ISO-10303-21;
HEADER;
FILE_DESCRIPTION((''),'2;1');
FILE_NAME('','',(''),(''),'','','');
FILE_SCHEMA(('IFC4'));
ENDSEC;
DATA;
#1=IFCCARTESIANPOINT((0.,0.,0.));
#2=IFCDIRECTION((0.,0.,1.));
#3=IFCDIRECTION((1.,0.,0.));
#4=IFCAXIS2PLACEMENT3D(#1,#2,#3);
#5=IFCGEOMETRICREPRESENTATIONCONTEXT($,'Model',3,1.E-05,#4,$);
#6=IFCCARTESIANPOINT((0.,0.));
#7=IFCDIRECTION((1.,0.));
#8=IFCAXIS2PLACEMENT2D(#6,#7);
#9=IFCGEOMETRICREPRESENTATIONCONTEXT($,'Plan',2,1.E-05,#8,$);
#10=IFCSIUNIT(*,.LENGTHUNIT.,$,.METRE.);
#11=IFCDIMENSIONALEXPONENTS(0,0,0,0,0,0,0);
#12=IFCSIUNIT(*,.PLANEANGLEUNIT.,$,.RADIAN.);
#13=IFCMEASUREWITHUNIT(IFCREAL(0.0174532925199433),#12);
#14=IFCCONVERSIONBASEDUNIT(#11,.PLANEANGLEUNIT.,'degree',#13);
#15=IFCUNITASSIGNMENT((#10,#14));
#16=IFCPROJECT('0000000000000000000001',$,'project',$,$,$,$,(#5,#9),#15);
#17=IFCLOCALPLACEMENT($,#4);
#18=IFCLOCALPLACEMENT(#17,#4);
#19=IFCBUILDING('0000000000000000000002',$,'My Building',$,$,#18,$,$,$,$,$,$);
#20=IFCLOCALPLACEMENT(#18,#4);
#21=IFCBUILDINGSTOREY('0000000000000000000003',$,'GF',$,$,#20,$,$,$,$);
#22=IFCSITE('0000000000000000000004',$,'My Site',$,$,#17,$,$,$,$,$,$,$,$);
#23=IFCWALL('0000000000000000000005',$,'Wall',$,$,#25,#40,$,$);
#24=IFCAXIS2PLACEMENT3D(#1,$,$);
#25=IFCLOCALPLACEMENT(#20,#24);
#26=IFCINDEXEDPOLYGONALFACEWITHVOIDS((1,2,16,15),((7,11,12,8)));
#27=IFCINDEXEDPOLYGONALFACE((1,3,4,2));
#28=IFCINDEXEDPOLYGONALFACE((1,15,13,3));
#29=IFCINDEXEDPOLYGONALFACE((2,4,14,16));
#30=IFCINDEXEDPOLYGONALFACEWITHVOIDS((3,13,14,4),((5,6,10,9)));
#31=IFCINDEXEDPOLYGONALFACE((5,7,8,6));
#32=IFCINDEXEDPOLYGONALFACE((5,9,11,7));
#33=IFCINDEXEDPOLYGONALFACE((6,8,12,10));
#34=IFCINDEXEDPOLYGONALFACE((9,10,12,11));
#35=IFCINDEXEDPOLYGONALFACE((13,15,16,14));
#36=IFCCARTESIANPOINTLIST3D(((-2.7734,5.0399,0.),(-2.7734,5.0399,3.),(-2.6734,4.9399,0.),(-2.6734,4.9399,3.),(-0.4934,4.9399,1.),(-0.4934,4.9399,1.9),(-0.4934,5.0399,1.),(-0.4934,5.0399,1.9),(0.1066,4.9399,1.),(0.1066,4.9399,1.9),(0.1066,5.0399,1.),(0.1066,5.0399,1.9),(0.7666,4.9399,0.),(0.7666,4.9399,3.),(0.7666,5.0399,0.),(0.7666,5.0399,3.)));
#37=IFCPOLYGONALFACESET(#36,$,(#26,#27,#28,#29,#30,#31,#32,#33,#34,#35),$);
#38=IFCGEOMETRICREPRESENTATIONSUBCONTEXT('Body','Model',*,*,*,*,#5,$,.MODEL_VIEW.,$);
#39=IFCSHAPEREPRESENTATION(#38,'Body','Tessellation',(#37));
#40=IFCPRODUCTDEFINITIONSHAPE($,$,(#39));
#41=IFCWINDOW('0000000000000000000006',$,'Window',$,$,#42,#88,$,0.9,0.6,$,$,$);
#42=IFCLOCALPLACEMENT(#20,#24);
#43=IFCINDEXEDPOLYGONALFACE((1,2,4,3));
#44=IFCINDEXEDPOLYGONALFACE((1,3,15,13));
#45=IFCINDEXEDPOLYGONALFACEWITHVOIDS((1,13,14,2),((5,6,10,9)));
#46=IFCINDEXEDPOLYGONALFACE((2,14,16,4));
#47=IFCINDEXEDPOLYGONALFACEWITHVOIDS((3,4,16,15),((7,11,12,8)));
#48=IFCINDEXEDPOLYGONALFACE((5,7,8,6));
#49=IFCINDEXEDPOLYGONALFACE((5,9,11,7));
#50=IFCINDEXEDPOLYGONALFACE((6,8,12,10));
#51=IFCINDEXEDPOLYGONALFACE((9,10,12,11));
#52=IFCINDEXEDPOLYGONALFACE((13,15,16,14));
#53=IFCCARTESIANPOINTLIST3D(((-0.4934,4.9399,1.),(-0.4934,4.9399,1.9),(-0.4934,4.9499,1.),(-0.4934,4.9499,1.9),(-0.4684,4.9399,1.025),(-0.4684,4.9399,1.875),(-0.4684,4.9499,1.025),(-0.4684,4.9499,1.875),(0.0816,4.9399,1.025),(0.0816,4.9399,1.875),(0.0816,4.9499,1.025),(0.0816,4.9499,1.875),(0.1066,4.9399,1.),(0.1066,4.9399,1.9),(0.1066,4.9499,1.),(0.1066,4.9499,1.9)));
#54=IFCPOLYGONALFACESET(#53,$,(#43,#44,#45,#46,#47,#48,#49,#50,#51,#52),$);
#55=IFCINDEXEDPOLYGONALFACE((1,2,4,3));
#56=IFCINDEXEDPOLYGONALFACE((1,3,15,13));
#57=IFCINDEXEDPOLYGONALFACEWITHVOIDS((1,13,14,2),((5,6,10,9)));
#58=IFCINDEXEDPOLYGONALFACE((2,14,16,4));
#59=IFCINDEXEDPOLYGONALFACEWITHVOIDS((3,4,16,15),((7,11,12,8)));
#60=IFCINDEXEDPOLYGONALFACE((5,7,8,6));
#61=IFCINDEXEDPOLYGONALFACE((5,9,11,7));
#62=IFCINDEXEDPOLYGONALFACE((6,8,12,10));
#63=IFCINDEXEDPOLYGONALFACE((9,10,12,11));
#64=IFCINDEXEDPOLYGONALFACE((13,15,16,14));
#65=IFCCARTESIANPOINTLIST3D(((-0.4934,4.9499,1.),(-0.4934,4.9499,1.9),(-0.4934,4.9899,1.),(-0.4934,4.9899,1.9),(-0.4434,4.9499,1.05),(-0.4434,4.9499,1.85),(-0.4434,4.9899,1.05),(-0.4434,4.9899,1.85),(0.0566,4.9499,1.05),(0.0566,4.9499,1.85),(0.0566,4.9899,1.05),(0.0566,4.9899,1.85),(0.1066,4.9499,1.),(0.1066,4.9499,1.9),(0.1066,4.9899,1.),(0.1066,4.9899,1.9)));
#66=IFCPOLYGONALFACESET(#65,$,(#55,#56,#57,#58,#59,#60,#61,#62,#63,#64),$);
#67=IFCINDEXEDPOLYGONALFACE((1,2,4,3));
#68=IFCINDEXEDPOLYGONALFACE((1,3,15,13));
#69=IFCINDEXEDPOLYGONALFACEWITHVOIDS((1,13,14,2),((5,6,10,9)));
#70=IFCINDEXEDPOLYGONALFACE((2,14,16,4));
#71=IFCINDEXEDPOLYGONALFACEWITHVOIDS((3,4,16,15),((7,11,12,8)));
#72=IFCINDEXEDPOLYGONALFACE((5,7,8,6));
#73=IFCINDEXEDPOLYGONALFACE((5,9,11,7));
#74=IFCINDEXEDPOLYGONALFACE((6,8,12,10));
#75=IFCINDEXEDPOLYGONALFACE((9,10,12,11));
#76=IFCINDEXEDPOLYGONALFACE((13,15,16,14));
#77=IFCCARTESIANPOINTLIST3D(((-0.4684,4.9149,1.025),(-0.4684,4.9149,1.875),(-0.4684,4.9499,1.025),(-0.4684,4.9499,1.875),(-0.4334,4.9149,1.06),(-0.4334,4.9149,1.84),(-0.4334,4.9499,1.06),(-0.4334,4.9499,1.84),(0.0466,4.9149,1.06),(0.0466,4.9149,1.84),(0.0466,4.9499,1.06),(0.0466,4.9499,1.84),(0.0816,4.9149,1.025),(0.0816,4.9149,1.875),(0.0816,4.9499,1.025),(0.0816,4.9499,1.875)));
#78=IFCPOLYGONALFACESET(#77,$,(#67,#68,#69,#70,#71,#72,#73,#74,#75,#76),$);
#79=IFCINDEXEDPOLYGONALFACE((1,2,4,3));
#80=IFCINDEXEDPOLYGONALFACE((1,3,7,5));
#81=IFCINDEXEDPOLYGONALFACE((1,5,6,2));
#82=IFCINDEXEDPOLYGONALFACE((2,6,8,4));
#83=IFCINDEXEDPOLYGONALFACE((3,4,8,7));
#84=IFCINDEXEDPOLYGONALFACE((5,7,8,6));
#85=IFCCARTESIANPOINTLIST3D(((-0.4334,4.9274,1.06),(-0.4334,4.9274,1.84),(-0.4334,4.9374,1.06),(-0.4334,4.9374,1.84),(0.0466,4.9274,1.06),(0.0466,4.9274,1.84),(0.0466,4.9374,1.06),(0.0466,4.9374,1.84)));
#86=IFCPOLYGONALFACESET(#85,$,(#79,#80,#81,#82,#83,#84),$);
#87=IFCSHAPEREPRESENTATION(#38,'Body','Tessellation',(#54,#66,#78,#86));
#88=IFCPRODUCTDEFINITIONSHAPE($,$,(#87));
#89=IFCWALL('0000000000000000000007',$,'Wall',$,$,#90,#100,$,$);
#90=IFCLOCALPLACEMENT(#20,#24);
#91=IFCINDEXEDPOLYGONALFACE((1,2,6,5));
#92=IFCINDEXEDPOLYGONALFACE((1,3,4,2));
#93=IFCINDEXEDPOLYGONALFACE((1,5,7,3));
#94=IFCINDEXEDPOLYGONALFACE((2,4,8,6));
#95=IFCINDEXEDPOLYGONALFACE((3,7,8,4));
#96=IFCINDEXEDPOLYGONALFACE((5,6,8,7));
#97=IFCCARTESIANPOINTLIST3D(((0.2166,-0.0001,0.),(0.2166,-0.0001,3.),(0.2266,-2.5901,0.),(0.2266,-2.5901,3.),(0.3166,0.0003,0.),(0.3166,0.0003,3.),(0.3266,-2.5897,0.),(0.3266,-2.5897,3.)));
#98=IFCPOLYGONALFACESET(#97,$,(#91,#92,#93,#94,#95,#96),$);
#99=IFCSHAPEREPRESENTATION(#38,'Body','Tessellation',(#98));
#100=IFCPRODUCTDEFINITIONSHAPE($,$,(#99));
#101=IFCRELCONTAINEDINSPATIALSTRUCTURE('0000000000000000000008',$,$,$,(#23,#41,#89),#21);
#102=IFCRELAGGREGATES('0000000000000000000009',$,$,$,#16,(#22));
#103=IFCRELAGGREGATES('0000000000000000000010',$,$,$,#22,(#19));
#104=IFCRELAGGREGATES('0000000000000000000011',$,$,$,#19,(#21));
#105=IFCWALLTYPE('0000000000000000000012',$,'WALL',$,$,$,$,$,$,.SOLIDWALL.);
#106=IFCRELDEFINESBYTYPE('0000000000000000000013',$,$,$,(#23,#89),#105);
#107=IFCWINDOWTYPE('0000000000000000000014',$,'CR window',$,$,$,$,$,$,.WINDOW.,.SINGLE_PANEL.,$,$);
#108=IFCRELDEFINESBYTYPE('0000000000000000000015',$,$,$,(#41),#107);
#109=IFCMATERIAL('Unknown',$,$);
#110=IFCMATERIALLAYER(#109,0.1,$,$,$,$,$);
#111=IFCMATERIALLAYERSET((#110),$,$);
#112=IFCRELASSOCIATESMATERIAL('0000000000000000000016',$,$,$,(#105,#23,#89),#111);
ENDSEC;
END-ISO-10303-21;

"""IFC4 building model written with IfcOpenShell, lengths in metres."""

from ifc_helpers import new_model, entity, si_unit, converted_unit, frame, origin_with_axes, origin_2d_with_axis, place, context, subcontext, project, spatial, line, indexed_curve, outline, extrude, shape, source, transform, mapped, material, layer, layer_set, layer_usage, type_object, type_shapes, element, fill, save


model = new_model("IFC4")

# Units and contexts
model_context = context("Model", 3, precision=1e-05, world=origin_with_axes())
plan_context = context("Plan", 2, precision=1e-05, world=origin_2d_with_axis())
body_context_1 = subcontext(model_context, "Body", "Model", "MODEL_VIEW")
body_context_2 = subcontext(plan_context, "Body", "Plan", "PLAN_VIEW")
ifc_project = project(units=[si_unit("LENGTHUNIT", "METRE"), converted_unit("PLANEANGLEUNIT", "degree", entity("IfcReal", 0.0174532925199433), si_unit("PLANEANGLEUNIT", "RADIAN"), dimensions=[0, 0, 0, 0, 0, 0, 0])], contexts=[model_context, plan_context])

# Site, building, storey
site_placement = place(None, origin_with_axes())
site = spatial("IfcSite", under=ifc_project, at=site_placement, Name="My Site")
building_placement = place(site_placement, origin_with_axes())
building = spatial("IfcBuilding", under=site, at=building_placement, Name="My Building")
storey_placement = place(building_placement, origin_with_axes())
storey = spatial("IfcBuildingStorey", under=building, at=storey_placement, Name="GF")

# Shared definitions
ifc_material = material(Name="Unknown")

# Shared definitions
ifc_layer_1 = layer(ifc_material, 0.1)
ifc_layer_set_1 = layer_set([ifc_layer_1])
wall_type_1 = type_object("IfcWallType", Name="WALL", PredefinedType="SOLIDWALL", material=ifc_layer_set_1)

# Wall, opening, window
ifc_layer_usage_1 = layer_usage(ifc_layer_set_1, "AXIS2", "POSITIVE", 0.0)
wall_1_placement = place(storey_placement, frame((0.7666, 5.0399, 0.0), z_axis=(0.0, 0.0, 1.0), x_axis=(-1.0, 0.0, 0.0)))
wall_1 = element("IfcWall", 1, at=wall_1_placement, inside=storey, type_object=wall_type_1, material=ifc_layer_usage_1, Name="Wall", context=body_context_1, shape_type="SweptSolid", body=[
    extrude(outline(indexed_curve([(0.0, 0.0), (0.0, 0.1), (3.44, 0.1), (3.54, 0.0)], segments=[line(1, 2, 3, 4, 1)])), origin_with_axes(), (0.0, 0.0, 1.0), 3.0),
])
shared_shape_1 = source(origin_with_axes(), body_context_1, "Body", "SweptSolid", [
    extrude(outline(indexed_curve([(0.0, 0.0), (0.6, 0.0), (0.6, 0.9), (0.0, 0.9)], segments=[line(1, 2, 3, 4, 1)])), frame((0.0, -0.6, 0.0), z_axis=(0.0, -1.0, 0.0), x_axis=(1.0, 0.0, 0.0)), (0.0, 0.0, -1.0), 1.2),
])
opening_1_placement = place(wall_1_placement, frame((0.66, 0.0, 1.0), z_axis=(0.0, 0.0, 1.0), x_axis=(1.0, 0.0, 0.0)))
opening_1 = element("IfcOpeningElement", 2, at=opening_1_placement, cuts=wall_1, PredefinedType="OPENING", context=body_context_1, shape_type="MappedRepresentation", body=[
    mapped(shared_shape_1, transform((0.0, 0.0, 0.0), x_axis=(1.0, 0.0, 0.0), y_axis=(0.0, 1.0, 0.0), z_axis=(0.0, 0.0, 1.0), scale=1.0)),
])
window_type_1 = type_object("IfcWindowType", Name="CR window", PartitioningType="SINGLE_PANEL", PredefinedType="WINDOW")
shared_shape_2 = source(origin_with_axes(), body_context_1, "Body", "SweptSolid", [
    extrude(outline(indexed_curve([(0.0, 0.0), (0.6, 0.0), (0.6, 0.9), (0.0, 0.9)], segments=[line(1, 2, 3, 4, 1)]), holes=[indexed_curve([(0.025, 0.025), (0.575, 0.025), (0.575, 0.875), (0.025, 0.875)], segments=[line(1, 2, 3, 4, 1)])]), frame((0.0, 0.09, 0.0), z_axis=(0.0, -1.0, 0.0), x_axis=(1.0, 0.0, 0.0)), (0.0, 0.0, -1.0), 0.01),
    extrude(outline(indexed_curve([(0.0, 0.0), (0.6, 0.0), (0.6, 0.9), (0.0, 0.9)], segments=[line(1, 2, 3, 4, 1)]), holes=[indexed_curve([(0.05, 0.05), (0.55, 0.05), (0.55, 0.85), (0.05, 0.85)], segments=[line(1, 2, 3, 4, 1)])]), frame((0.0, 0.05, 0.0), z_axis=(0.0, -1.0, 0.0), x_axis=(1.0, 0.0, 0.0)), (0.0, 0.0, -1.0), 0.04),
    extrude(outline(indexed_curve([(0.0, 0.0), (0.55, 0.0), (0.55, 0.85), (0.0, 0.85)], segments=[line(1, 2, 3, 4, 1)]), holes=[indexed_curve([(0.035, 0.035), (0.515, 0.035), (0.515, 0.815), (0.035, 0.815)], segments=[line(1, 2, 3, 4, 1)])]), frame((0.025, 0.09, 0.025), z_axis=(0.0, -1.0, 0.0), x_axis=(1.0, 0.0, 0.0)), (0.0, 0.0, -1.0), 0.035),
    extrude(outline(indexed_curve([(0.035, 0.035), (0.515, 0.035), (0.515, 0.815), (0.035, 0.815)], segments=[line(1, 2, 3, 4, 1)])), frame((0.025, 0.1025, 0.025), z_axis=(0.0, -1.0, 0.0), x_axis=(1.0, 0.0, 0.0)), (0.0, 0.0, -1.0), 0.01),
])
shared_shape_3 = source(origin_with_axes(), body_context_2, "Body", "Curve2D", [
    entity("IfcIndexedPolyCurve", entity("IfcCartesianPointList2D", [[0.05, 0.05], [0.55, 0.05]])),
    entity("IfcIndexedPolyCurve", entity("IfcCartesianPointList2D", [[0.0, 0.1], [0.025, 0.1], [0.025, 0.09], [0.05, 0.09], [0.05, 0.05], [0.0, 0.05]]), [entity("IfcLineIndex", [1, 2, 3, 4, 5, 6, 1])]),
    entity("IfcIndexedPolyCurve", entity("IfcCartesianPointList2D", [[0.6, 0.1], [0.575, 0.1], [0.575, 0.09], [0.55, 0.09], [0.55, 0.05], [0.6, 0.05]]), [entity("IfcLineIndex", [1, 2, 3, 4, 5, 6, 1])]),
    entity("IfcIndexedPolyCurve", entity("IfcCartesianPointList2D", [[0.025, 0.09], [0.06, 0.09], [0.06, 0.125], [0.025, 0.125]]), [entity("IfcLineIndex", [1, 2, 3, 4, 1])]),
    entity("IfcIndexedPolyCurve", entity("IfcCartesianPointList2D", [[0.575, 0.09], [0.54, 0.09], [0.54, 0.125], [0.575, 0.125]]), [entity("IfcLineIndex", [1, 2, 3, 4, 1])]),
    entity("IfcIndexedPolyCurve", entity("IfcCartesianPointList2D", [[0.06, 0.09], [0.54, 0.09]])),
    entity("IfcIndexedPolyCurve", entity("IfcCartesianPointList2D", [[0.06, 0.125], [0.54, 0.125]])),
    entity("IfcIndexedPolyCurve", entity("IfcCartesianPointList2D", [[0.06, 0.1075], [0.54, 0.1075]])),
])
type_shapes(window_type_1, [shared_shape_2, shared_shape_3])
window_1_placement = place(opening_1_placement, origin_with_axes())
window_1 = element("IfcWindow", 3, at=window_1_placement, inside=storey, type_object=window_type_1, Name="Window", OverallHeight=0.9, OverallWidth=0.6, shapes=[
    shape(body_context_1, "Body", "MappedRepresentation", [mapped(shared_shape_2, transform((0.0, 0.0, 0.0), x_axis=(1.0, 0.0, 0.0), y_axis=(0.0, 1.0, 0.0), z_axis=(0.0, 0.0, 1.0), scale=1.0))]),
    shape(body_context_2, "Body", "MappedRepresentation", [mapped(shared_shape_3, transform((0.0, 0.0, 0.0), x_axis=(1.0, 0.0, 0.0), y_axis=(0.0, 1.0, 0.0), z_axis=(0.0, 0.0, 1.0), scale=1.0))]),
])
fill(opening_1, window_1)

# Wall
ifc_layer_usage_2 = layer_usage(ifc_layer_set_1, "AXIS2", "POSITIVE", 0.0)
wall_2_placement = place(storey_placement, frame((0.2166, -0.0001, 0.0), z_axis=(0.0, 0.0, 1.0), x_axis=(0.003861, -0.999993, 0.0)))
element("IfcWall", 4, at=wall_2_placement, inside=storey, type_object=wall_type_1, material=ifc_layer_usage_2, Name="Wall", context=body_context_1, shape_type="SweptSolid", body=[
    extrude(outline(indexed_curve([(0.0, 0.0), (0.0, 0.1), (2.59, 0.1), (2.59, 0.0)], segments=[line(1, 2, 3, 4, 1)])), origin_with_axes(), (0.0, 0.0, 1.0), 3.0),
])

save(model, "model.ifc")
